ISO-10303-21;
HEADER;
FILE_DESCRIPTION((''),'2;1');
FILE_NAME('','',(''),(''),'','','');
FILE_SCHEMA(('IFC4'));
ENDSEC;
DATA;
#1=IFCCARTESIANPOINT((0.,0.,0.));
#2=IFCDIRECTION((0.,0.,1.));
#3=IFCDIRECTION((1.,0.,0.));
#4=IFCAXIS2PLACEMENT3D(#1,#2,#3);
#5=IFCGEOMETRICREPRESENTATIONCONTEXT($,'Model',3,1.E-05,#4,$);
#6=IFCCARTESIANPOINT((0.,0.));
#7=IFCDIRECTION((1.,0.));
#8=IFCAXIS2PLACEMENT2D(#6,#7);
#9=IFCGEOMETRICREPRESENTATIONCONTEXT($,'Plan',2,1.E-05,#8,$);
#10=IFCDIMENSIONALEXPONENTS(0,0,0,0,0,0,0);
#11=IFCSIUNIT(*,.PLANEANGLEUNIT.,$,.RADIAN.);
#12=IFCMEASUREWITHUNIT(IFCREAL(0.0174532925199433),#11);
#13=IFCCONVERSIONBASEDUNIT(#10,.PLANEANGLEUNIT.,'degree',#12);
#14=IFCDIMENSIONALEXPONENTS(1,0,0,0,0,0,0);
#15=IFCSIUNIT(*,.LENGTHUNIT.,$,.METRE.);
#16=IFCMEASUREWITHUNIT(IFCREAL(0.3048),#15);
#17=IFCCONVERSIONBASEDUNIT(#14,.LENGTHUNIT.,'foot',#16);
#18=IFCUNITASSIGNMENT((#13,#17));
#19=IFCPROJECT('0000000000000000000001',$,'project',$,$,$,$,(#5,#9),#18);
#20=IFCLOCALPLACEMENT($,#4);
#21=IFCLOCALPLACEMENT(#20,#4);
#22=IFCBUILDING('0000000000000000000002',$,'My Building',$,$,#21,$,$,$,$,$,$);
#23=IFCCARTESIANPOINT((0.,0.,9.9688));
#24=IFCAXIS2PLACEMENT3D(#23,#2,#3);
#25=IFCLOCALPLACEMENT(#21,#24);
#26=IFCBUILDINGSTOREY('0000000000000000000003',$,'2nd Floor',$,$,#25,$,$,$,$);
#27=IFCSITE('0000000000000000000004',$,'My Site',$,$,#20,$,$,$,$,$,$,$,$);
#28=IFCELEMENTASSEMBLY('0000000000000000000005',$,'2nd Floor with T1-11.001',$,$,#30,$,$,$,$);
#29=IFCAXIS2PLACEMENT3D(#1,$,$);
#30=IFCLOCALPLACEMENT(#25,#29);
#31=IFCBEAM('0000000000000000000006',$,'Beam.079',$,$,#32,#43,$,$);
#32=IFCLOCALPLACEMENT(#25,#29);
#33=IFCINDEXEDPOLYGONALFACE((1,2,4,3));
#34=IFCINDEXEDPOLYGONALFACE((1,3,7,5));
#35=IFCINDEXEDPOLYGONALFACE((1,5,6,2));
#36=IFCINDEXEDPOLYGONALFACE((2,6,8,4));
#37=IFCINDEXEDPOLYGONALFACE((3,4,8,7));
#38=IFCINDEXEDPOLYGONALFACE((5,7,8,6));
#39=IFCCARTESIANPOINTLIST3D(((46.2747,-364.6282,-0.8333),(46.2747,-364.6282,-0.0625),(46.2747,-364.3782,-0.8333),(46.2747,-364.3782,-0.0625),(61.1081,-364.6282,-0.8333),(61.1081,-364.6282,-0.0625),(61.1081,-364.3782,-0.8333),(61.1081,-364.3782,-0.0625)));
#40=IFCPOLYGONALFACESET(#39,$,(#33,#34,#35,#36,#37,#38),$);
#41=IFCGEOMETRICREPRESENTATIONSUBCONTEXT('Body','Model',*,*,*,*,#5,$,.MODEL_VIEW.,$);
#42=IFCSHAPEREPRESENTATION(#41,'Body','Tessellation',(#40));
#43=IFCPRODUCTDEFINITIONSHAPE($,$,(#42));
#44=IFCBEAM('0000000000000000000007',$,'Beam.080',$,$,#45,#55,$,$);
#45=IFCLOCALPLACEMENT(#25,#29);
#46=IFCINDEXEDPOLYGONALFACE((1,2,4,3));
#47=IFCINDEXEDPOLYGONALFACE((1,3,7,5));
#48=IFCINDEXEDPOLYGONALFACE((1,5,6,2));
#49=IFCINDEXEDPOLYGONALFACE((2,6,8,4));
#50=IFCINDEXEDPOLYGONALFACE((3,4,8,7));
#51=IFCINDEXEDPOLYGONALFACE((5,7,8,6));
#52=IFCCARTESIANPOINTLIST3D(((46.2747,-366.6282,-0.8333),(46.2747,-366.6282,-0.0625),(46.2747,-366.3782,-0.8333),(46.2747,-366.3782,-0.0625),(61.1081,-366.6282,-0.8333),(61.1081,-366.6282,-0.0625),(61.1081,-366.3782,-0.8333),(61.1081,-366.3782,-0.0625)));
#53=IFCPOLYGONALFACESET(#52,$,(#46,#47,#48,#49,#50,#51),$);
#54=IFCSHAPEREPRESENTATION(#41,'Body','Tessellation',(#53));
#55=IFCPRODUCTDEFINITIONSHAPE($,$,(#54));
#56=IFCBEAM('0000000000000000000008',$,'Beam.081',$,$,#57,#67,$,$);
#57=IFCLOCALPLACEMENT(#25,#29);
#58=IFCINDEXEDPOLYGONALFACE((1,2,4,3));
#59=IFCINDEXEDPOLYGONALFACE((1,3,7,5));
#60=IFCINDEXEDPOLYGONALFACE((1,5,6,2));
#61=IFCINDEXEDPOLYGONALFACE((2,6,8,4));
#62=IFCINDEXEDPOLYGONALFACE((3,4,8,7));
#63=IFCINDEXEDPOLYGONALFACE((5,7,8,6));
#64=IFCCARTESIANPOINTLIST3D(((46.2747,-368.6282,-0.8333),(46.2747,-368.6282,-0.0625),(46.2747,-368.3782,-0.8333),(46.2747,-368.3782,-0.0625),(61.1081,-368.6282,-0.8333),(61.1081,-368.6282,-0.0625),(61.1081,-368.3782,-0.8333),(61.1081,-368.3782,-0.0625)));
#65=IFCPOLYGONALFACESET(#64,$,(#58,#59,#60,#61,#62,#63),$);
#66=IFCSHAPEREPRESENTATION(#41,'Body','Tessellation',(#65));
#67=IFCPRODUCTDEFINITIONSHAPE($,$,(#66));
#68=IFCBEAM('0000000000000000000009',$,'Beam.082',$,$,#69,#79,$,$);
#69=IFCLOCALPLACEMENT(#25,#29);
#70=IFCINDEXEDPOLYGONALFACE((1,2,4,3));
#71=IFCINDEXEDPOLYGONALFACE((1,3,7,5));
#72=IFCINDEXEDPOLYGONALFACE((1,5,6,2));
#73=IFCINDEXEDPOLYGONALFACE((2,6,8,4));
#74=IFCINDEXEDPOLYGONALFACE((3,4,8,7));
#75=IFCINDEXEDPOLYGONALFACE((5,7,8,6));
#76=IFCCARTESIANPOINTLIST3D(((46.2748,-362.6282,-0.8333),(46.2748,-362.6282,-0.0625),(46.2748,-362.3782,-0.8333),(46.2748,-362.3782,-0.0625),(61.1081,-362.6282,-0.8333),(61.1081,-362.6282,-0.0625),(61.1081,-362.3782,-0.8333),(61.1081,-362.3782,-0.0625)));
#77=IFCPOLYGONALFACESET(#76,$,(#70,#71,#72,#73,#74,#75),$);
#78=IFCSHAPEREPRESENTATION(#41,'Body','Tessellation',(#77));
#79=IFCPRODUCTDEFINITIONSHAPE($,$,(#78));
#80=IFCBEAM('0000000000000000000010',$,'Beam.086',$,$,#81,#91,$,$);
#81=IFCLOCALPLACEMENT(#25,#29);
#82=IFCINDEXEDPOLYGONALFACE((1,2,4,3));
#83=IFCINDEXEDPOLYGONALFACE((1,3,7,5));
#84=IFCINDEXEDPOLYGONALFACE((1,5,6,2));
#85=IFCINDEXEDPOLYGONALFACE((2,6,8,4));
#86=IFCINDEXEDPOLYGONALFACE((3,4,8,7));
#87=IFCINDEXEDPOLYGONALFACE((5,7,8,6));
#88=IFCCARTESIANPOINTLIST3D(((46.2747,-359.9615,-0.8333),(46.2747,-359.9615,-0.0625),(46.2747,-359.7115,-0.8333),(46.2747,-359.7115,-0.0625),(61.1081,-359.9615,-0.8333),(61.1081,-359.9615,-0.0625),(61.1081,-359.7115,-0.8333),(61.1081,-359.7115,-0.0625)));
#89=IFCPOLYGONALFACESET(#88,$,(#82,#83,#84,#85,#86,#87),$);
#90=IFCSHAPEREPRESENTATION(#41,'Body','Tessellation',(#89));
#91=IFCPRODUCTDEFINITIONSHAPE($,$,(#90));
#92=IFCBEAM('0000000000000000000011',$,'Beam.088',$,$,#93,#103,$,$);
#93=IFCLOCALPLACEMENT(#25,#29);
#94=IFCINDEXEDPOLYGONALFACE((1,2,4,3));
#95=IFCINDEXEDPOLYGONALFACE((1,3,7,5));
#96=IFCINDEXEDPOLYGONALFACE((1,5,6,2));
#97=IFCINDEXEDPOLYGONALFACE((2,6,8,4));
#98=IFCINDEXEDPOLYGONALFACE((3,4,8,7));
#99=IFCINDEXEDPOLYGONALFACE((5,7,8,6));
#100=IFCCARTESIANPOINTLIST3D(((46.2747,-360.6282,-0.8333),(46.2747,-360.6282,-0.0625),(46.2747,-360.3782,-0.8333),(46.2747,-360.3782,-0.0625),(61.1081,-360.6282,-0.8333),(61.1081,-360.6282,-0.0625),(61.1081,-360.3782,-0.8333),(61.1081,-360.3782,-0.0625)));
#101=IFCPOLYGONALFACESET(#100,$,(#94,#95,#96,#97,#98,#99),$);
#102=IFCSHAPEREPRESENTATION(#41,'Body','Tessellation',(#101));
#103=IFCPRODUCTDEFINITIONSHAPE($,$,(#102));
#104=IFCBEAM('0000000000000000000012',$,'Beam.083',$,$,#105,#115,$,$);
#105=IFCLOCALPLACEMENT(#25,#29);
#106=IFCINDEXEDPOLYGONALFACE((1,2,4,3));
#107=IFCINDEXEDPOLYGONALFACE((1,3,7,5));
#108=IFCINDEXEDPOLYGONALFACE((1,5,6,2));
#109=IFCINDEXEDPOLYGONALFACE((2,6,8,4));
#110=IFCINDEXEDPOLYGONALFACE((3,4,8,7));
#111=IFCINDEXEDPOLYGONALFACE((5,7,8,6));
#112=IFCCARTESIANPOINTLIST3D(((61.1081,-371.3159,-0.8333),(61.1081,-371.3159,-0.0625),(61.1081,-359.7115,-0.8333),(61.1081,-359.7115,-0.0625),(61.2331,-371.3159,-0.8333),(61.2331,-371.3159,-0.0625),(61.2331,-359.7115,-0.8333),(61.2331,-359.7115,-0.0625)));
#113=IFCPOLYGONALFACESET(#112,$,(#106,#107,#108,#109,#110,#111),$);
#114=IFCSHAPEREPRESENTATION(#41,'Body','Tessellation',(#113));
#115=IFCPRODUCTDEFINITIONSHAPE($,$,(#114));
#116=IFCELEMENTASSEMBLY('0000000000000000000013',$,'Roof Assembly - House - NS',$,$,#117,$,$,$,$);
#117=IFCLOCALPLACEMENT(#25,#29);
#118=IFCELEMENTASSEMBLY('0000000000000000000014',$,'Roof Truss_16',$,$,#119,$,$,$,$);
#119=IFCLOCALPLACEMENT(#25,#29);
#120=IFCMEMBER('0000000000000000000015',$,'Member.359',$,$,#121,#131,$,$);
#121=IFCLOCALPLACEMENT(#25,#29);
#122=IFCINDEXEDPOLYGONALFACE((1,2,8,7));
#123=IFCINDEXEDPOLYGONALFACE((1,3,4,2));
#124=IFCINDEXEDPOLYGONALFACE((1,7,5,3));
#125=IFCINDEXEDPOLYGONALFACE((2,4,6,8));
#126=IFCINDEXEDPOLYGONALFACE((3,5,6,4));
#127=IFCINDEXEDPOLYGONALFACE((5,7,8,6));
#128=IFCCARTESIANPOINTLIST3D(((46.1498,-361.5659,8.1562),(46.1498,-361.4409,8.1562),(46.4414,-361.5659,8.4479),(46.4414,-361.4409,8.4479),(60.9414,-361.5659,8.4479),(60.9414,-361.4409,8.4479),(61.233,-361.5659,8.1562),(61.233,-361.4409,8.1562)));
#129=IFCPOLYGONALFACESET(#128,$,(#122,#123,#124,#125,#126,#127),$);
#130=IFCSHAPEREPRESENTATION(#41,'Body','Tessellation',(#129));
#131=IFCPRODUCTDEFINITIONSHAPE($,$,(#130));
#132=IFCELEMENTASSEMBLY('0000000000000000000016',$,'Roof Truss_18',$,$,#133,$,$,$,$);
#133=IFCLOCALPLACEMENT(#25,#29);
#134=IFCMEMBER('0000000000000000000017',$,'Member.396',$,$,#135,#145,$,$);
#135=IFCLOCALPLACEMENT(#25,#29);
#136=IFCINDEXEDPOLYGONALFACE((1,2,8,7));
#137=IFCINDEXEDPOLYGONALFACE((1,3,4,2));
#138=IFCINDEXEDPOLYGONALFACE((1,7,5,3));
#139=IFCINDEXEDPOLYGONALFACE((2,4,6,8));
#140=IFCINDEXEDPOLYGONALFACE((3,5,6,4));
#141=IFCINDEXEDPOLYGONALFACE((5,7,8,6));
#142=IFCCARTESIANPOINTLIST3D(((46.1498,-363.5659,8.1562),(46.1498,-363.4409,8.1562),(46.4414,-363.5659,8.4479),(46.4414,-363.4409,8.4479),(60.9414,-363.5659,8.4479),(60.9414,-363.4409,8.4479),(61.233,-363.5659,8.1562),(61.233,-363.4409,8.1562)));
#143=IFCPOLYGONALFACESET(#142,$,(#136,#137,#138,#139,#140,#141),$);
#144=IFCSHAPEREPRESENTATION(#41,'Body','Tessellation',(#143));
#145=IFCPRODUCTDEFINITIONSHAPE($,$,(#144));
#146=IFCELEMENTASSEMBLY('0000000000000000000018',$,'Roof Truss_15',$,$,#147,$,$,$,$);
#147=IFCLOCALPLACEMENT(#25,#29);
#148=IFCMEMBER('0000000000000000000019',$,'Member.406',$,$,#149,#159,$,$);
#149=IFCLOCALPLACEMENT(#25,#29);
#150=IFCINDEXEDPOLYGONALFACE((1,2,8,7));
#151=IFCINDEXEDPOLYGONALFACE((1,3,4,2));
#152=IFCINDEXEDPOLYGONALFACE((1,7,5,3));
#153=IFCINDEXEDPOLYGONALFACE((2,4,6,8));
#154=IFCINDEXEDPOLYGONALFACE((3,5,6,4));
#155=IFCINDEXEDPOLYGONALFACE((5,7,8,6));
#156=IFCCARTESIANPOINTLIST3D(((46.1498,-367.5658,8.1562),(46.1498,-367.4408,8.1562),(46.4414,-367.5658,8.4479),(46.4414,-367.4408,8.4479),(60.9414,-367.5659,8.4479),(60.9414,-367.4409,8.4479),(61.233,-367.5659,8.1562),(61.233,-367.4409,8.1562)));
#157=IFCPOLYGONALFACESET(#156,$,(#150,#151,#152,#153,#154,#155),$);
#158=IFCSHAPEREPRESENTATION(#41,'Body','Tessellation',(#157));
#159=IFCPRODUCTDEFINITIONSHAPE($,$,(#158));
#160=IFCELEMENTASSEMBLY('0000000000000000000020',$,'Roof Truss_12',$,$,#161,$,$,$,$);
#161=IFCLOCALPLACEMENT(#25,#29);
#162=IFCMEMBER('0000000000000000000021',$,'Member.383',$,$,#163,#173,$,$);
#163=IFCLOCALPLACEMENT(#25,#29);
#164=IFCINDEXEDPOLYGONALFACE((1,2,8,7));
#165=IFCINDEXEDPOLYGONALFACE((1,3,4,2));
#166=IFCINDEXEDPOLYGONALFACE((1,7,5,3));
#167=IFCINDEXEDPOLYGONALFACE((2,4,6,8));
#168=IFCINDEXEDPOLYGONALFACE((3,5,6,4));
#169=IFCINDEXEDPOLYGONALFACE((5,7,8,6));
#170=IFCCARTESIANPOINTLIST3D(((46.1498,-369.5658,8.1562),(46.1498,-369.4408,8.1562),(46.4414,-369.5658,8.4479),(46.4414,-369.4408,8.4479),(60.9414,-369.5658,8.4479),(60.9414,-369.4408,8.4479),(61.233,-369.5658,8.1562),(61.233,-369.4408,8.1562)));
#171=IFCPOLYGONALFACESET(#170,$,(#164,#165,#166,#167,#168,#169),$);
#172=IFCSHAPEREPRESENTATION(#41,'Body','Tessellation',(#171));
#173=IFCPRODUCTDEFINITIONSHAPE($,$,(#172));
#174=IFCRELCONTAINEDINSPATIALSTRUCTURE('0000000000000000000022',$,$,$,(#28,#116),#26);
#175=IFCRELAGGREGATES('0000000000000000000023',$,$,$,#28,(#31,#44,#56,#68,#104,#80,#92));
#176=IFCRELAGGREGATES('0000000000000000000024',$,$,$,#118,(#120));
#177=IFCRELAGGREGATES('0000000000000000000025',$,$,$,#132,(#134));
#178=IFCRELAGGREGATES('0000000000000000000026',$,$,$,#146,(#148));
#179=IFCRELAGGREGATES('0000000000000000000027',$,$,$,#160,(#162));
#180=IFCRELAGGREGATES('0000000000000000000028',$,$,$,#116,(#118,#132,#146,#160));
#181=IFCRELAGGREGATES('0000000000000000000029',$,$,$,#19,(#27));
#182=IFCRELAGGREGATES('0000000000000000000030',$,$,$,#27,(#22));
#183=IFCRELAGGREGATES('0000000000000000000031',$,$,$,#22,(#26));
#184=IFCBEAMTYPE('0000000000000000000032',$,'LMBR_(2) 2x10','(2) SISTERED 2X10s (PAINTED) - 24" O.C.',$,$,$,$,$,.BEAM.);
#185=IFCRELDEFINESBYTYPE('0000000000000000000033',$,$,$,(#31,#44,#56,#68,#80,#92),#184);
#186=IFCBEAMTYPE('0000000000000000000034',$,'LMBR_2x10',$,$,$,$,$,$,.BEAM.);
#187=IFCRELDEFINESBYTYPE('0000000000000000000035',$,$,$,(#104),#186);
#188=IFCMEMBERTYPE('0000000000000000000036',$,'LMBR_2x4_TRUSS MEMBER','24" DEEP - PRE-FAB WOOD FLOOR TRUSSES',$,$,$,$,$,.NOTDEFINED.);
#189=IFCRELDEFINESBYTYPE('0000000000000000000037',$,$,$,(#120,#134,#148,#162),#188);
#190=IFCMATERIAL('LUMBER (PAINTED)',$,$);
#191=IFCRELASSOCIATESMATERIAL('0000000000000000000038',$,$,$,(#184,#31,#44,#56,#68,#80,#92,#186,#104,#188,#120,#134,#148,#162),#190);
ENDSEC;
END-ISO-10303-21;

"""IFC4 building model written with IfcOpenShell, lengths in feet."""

from ifc_helpers import new_model, entity, si_unit, converted_unit, frame, origin_with_axes, origin_2d_with_axis, place, context, subcontext, project, spatial, indexed_curve, outline, extrude, clip, halfspace, material, material_profile, profile_set, profile_usage, type_object, element, aggregate, save


model = new_model("IFC4")

# Units and contexts
model_context = context("Model", 3, precision=1e-05, world=origin_with_axes())
plan_context = context("Plan", 2, precision=1e-05, world=origin_2d_with_axis())
body_context = subcontext(model_context, "Body", "Model", "MODEL_VIEW")
ifc_project = project(units=[converted_unit("PLANEANGLEUNIT", "degree", entity("IfcReal", 0.0174532925199433), si_unit("PLANEANGLEUNIT", "RADIAN"), dimensions=[0, 0, 0, 0, 0, 0, 0]), converted_unit("LENGTHUNIT", "foot", entity("IfcReal", 0.3048), si_unit("LENGTHUNIT", "METRE"), dimensions=[1, 0, 0, 0, 0, 0, 0])], contexts=[model_context, plan_context])

# Site, building, storey
site_placement = place(None, origin_with_axes())
site = spatial("IfcSite", under=ifc_project, at=site_placement, Name="My Site")
building_placement = place(site_placement, origin_with_axes())
building = spatial("IfcBuilding", under=site, at=building_placement, Name="My Building")
storey_placement = place(building_placement, frame((0.0, 0.0, 9.9688), z_axis=(0.0, 0.0, 1.0), x_axis=(1.0, 0.0, 0.0)))
storey = spatial("IfcBuildingStorey", under=building, at=storey_placement, Name="2nd Floor")

# Element assembly, beams
assembly_1_placement = place(storey_placement, frame((46.1498, -359.5866, -0.0625), z_axis=(0.0, 0.0, 1.0), x_axis=(1.0, 0.0, 0.0)))
assembly_1 = element("IfcElementAssembly", 1, at=assembly_1_placement, inside=storey, Name="2nd Floor with T1-11.001")
ifc_material_1 = material(Name="LUMBER (PAINTED)")
ifc_material_profile_1 = material_profile(ifc_material_1, outline(indexed_curve([(-0.125, 0.3854), (0.125, 0.3854), (0.125, -0.3854), (-0.125, -0.3854), (-0.125, 0.3854)])))
ifc_profile_set_1 = profile_set([ifc_material_profile_1])
ifc_profile_usage_1 = profile_usage(ifc_profile_set_1, cardinal=5)
beam_type_1 = type_object("IfcBeamType", Name="LMBR_(2) 2x10", Description="(2) SISTERED 2X10s (PAINTED) - 24\" O.C.", PredefinedType="BEAM", material=ifc_profile_set_1)
beam_1_placement = place(assembly_1_placement, frame((14.9583, -4.9167, -0.3854), z_axis=(-1.0, 0.0, 0.0), x_axis=(0.0, -1.0, 0.0)))
beam_1 = element("IfcBeam", 2, at=beam_1_placement, type_object=beam_type_1, material=ifc_profile_usage_1, Name="Beam.079", context=body_context, shape_type="SweptSolid", body=[
    extrude(outline(indexed_curve([(-0.125, 0.3854), (0.125, 0.3854), (0.125, -0.3854), (-0.125, -0.3854), (-0.125, 0.3854)])), origin_with_axes(), (0.0, 0.0, 1.0), 14.8333),
])
ifc_profile_usage_2 = profile_usage(ifc_profile_set_1, cardinal=5)
beam_2_placement = place(assembly_1_placement, frame((14.9583, -6.9167, -0.3854), z_axis=(-1.0, 0.0, 0.0), x_axis=(0.0, -1.0, 0.0)))
beam_2 = element("IfcBeam", 3, at=beam_2_placement, type_object=beam_type_1, material=ifc_profile_usage_2, Name="Beam.080", context=body_context, shape_type="SweptSolid", body=[
    extrude(outline(indexed_curve([(-0.125, 0.3854), (0.125, 0.3854), (0.125, -0.3854), (-0.125, -0.3854), (-0.125, 0.3854)])), origin_with_axes(), (0.0, 0.0, 1.0), 14.8333),
])
ifc_profile_usage_3 = profile_usage(ifc_profile_set_1, cardinal=5)
beam_3_placement = place(assembly_1_placement, frame((14.9583, -8.9167, -0.3854), z_axis=(-1.0, 0.0, 0.0), x_axis=(0.0, -1.0, 0.0)))
beam_3 = element("IfcBeam", 4, at=beam_3_placement, type_object=beam_type_1, material=ifc_profile_usage_3, Name="Beam.081", context=body_context, shape_type="SweptSolid", body=[
    extrude(outline(indexed_curve([(-0.125, 0.3854), (0.125, 0.3854), (0.125, -0.3854), (-0.125, -0.3854), (-0.125, 0.3854)])), origin_with_axes(), (0.0, 0.0, 1.0), 14.8333),
])
ifc_profile_usage_4 = profile_usage(ifc_profile_set_1, cardinal=5)
beam_4_placement = place(assembly_1_placement, frame((14.9583, -2.9167, -0.3854), z_axis=(-1.0, 0.0, 0.0), x_axis=(0.0, -1.0, 0.0)))
beam_4 = element("IfcBeam", 5, at=beam_4_placement, type_object=beam_type_1, material=ifc_profile_usage_4, Name="Beam.082", context=body_context, shape_type="SweptSolid", body=[
    extrude(outline(indexed_curve([(-0.125, 0.3854), (0.125, 0.3854), (0.125, -0.3854), (-0.125, -0.3854), (-0.125, 0.3854)])), origin_with_axes(), (0.0, 0.0, 1.0), 14.8333),
])
ifc_profile_usage_5 = profile_usage(ifc_profile_set_1, cardinal=5)
beam_5_placement = place(assembly_1_placement, frame((14.9583, -0.25, -0.3854), z_axis=(-1.0, 0.0, 0.0), x_axis=(0.0, -1.0, 0.0)))
beam_5 = element("IfcBeam", 6, at=beam_5_placement, type_object=beam_type_1, material=ifc_profile_usage_5, Name="Beam.086", context=body_context, shape_type="SweptSolid", body=[
    extrude(outline(indexed_curve([(-0.125, 0.3854), (0.125, 0.3854), (0.125, -0.3854), (-0.125, -0.3854), (-0.125, 0.3854)])), origin_with_axes(), (0.0, 0.0, 1.0), 14.8333),
])
ifc_profile_usage_6 = profile_usage(ifc_profile_set_1, cardinal=5)
beam_6_placement = place(assembly_1_placement, frame((14.9583, -0.9167, -0.3854), z_axis=(-1.0, 0.0, 0.0), x_axis=(0.0, -1.0, 0.0)))
beam_6 = element("IfcBeam", 7, at=beam_6_placement, type_object=beam_type_1, material=ifc_profile_usage_6, Name="Beam.088", context=body_context, shape_type="SweptSolid", body=[
    extrude(outline(indexed_curve([(-0.125, 0.3854), (0.125, 0.3854), (0.125, -0.3854), (-0.125, -0.3854), (-0.125, 0.3854)])), origin_with_axes(), (0.0, 0.0, 1.0), 14.8333),
])
ifc_material_profile_2 = material_profile(ifc_material_1, outline(indexed_curve([(-0.0625, 0.3854), (0.0625, 0.3854), (0.0625, -0.3854), (-0.0625, -0.3854), (-0.0625, 0.3854)])))
ifc_profile_set_2 = profile_set([ifc_material_profile_2])
ifc_profile_usage_7 = profile_usage(ifc_profile_set_2)
beam_type_2 = type_object("IfcBeamType", Name="LMBR_2x10", PredefinedType="BEAM", material=ifc_profile_set_2)
beam_7_placement = place(assembly_1_placement, frame((15.0208, -0.125, -0.3854), z_axis=(0.0, -1.0, 0.0), x_axis=(1.0, 0.0, 0.0)))
beam_7 = element("IfcBeam", 8, at=beam_7_placement, type_object=beam_type_2, material=ifc_profile_usage_7, Name="Beam.083", context=body_context, shape_type="SweptSolid", body=[
    extrude(outline(indexed_curve([(-0.0625, 0.3854), (0.0625, 0.3854), (0.0625, -0.3854), (-0.0625, -0.3854), (-0.0625, 0.3854)])), origin_with_axes(), (0.0, 0.0, 1.0), 11.6043),
])
aggregate(assembly_1, [beam_1, beam_2, beam_3, beam_4, beam_7, beam_5, beam_6])

# Element assemblies, members
assembly_2_placement = place(storey_placement, frame((0.0, 0.0, -9.9688), z_axis=(0.0, 0.0, 1.0), x_axis=(1.0, 0.0, 0.0)))
assembly_2 = element("IfcElementAssembly", 9, at=assembly_2_placement, inside=storey, Name="Roof Assembly - House - NS")
assembly_3_placement = place(assembly_2_placement, frame((53.6914, -361.5034, 21.6754), z_axis=(0.0, 0.0, 1.0), x_axis=(1.0, 0.0, 0.0)))
assembly_3 = element("IfcElementAssembly", 10, at=assembly_3_placement, Name="Roof Truss_16")
ifc_material_profile_3 = material_profile(ifc_material_1, outline(indexed_curve([(-0.0625, -0.1458), (0.0625, -0.1458), (0.0625, 0.1458), (-0.0625, 0.1458), (-0.0625, -0.1458)])))
ifc_profile_set_3 = profile_set([ifc_material_profile_3])
member_type_1 = type_object("IfcMemberType", Name="LMBR_2x4_TRUSS MEMBER", Description="24\" DEEP - PRE-FAB WOOD FLOOR TRUSSES", PredefinedType="NOTDEFINED", material=ifc_profile_set_3)
ifc_profile_usage_8 = profile_usage(ifc_profile_set_3)
member_1_placement = place(assembly_3_placement, frame((7.5416, 0.0, -3.4046), z_axis=(-1.0, 0.0, 0.0), x_axis=(0.0, 1.0, 0.0)))
member_1 = element("IfcMember", 11, at=member_1_placement, type_object=member_type_1, material=ifc_profile_usage_8, Name="Member.359", context=body_context, shape_type="Clipping", body=[
    clip(clip(extrude(outline(indexed_curve([(-0.0625, -0.1458), (0.0625, -0.1458), (0.0625, 0.1458), (-0.0625, 0.1458), (-0.0625, -0.1458)])), origin_with_axes(), (0.0, 0.0, 1.0), 15.0833), halfspace(frame((397.5032, 0.1458, 0.0001), z_axis=(0.0, -0.707114, -0.707099), x_axis=(-1.0, 0.0, 0.0)), False)), halfspace(frame((397.5032, 0.1458, 15.0832), z_axis=(0.0, -0.707107, 0.707107), x_axis=(-1.0, 0.0, 0.0)), False)),
])
aggregate(assembly_3, [member_1])
assembly_4_placement = place(assembly_2_placement, frame((53.6914, -363.5034, 21.6754), z_axis=(0.0, 0.0, 1.0), x_axis=(1.0, 0.0, 0.0)))
assembly_4 = element("IfcElementAssembly", 12, at=assembly_4_placement, Name="Roof Truss_18")
ifc_profile_usage_9 = profile_usage(ifc_profile_set_3)
member_2_placement = place(assembly_4_placement, frame((7.5416, 0.0, -3.4046), z_axis=(-1.0, 0.0, 0.0), x_axis=(0.0, 1.0, 0.0)))
member_2 = element("IfcMember", 13, at=member_2_placement, type_object=member_type_1, material=ifc_profile_usage_9, Name="Member.396", context=body_context, shape_type="Clipping", body=[
    clip(clip(extrude(outline(indexed_curve([(-0.0625, -0.1458), (0.0625, -0.1458), (0.0625, 0.1458), (-0.0625, 0.1458), (-0.0625, -0.1458)])), origin_with_axes(), (0.0, 0.0, 1.0), 15.0833), halfspace(frame((397.5032, 0.1458, 0.0001), z_axis=(0.0, -0.707114, -0.707099), x_axis=(-1.0, 0.0, 0.0)), False)), halfspace(frame((397.5032, 0.1458, 15.0832), z_axis=(0.0, -0.707107, 0.707107), x_axis=(-1.0, 0.0, 0.0)), False)),
])
aggregate(assembly_4, [member_2])
assembly_5_placement = place(assembly_2_placement, frame((53.6914, -367.5034, 21.6754), z_axis=(0.0, 0.0, 1.0), x_axis=(1.0, 0.0, 0.0)))
assembly_5 = element("IfcElementAssembly", 14, at=assembly_5_placement, Name="Roof Truss_15")
ifc_profile_usage_10 = profile_usage(ifc_profile_set_3)
member_3_placement = place(assembly_5_placement, frame((7.5416, 0.0, -3.4046), z_axis=(-1.0, 0.0, 0.0), x_axis=(0.0, 1.0, 0.0)))
member_3 = element("IfcMember", 15, at=member_3_placement, type_object=member_type_1, material=ifc_profile_usage_10, Name="Member.406", context=body_context, shape_type="Clipping", body=[
    clip(clip(extrude(outline(indexed_curve([(-0.0625, -0.1458), (0.0625, -0.1458), (0.0625, 0.1458), (-0.0625, 0.1458), (-0.0625, -0.1458)])), origin_with_axes(), (0.0, 0.0, 1.0), 15.0833), halfspace(frame((397.5032, 0.1458, 0.0001), z_axis=(0.0, -0.707114, -0.707099), x_axis=(-1.0, 0.0, 0.0)), False)), halfspace(frame((397.5032, 0.1458, 15.0832), z_axis=(0.0, -0.707107, 0.707107), x_axis=(-1.0, 0.0, 0.0)), False)),
])
aggregate(assembly_5, [member_3])
assembly_6_placement = place(assembly_2_placement, frame((53.6914, -369.5033, 21.6754), z_axis=(0.0, 0.0, 1.0), x_axis=(1.0, 0.0, 0.0)))
assembly_6 = element("IfcElementAssembly", 16, at=assembly_6_placement, Name="Roof Truss_12")
ifc_profile_usage_11 = profile_usage(ifc_profile_set_3)
member_4_placement = place(assembly_6_placement, frame((7.5416, 0.0, -3.4046), z_axis=(-1.0, 0.0, 0.0), x_axis=(0.0, 1.0, 0.0)))
member_4 = element("IfcMember", 17, at=member_4_placement, type_object=member_type_1, material=ifc_profile_usage_11, Name="Member.383", context=body_context, shape_type="Clipping", body=[
    clip(clip(extrude(outline(indexed_curve([(-0.0625, -0.1458), (0.0625, -0.1458), (0.0625, 0.1458), (-0.0625, 0.1458), (-0.0625, -0.1458)])), origin_with_axes(), (0.0, 0.0, 1.0), 15.0833), halfspace(frame((397.5032, 0.1458, 0.0001), z_axis=(0.0, -0.707114, -0.707099), x_axis=(-1.0, 0.0, 0.0)), False)), halfspace(frame((397.5032, 0.1458, 15.0832), z_axis=(0.0, -0.707107, 0.707107), x_axis=(-1.0, 0.0, 0.0)), False)),
])
aggregate(assembly_6, [member_4])

aggregate(assembly_2, [assembly_3, assembly_4, assembly_5, assembly_6])

save(model, "model.ifc")
